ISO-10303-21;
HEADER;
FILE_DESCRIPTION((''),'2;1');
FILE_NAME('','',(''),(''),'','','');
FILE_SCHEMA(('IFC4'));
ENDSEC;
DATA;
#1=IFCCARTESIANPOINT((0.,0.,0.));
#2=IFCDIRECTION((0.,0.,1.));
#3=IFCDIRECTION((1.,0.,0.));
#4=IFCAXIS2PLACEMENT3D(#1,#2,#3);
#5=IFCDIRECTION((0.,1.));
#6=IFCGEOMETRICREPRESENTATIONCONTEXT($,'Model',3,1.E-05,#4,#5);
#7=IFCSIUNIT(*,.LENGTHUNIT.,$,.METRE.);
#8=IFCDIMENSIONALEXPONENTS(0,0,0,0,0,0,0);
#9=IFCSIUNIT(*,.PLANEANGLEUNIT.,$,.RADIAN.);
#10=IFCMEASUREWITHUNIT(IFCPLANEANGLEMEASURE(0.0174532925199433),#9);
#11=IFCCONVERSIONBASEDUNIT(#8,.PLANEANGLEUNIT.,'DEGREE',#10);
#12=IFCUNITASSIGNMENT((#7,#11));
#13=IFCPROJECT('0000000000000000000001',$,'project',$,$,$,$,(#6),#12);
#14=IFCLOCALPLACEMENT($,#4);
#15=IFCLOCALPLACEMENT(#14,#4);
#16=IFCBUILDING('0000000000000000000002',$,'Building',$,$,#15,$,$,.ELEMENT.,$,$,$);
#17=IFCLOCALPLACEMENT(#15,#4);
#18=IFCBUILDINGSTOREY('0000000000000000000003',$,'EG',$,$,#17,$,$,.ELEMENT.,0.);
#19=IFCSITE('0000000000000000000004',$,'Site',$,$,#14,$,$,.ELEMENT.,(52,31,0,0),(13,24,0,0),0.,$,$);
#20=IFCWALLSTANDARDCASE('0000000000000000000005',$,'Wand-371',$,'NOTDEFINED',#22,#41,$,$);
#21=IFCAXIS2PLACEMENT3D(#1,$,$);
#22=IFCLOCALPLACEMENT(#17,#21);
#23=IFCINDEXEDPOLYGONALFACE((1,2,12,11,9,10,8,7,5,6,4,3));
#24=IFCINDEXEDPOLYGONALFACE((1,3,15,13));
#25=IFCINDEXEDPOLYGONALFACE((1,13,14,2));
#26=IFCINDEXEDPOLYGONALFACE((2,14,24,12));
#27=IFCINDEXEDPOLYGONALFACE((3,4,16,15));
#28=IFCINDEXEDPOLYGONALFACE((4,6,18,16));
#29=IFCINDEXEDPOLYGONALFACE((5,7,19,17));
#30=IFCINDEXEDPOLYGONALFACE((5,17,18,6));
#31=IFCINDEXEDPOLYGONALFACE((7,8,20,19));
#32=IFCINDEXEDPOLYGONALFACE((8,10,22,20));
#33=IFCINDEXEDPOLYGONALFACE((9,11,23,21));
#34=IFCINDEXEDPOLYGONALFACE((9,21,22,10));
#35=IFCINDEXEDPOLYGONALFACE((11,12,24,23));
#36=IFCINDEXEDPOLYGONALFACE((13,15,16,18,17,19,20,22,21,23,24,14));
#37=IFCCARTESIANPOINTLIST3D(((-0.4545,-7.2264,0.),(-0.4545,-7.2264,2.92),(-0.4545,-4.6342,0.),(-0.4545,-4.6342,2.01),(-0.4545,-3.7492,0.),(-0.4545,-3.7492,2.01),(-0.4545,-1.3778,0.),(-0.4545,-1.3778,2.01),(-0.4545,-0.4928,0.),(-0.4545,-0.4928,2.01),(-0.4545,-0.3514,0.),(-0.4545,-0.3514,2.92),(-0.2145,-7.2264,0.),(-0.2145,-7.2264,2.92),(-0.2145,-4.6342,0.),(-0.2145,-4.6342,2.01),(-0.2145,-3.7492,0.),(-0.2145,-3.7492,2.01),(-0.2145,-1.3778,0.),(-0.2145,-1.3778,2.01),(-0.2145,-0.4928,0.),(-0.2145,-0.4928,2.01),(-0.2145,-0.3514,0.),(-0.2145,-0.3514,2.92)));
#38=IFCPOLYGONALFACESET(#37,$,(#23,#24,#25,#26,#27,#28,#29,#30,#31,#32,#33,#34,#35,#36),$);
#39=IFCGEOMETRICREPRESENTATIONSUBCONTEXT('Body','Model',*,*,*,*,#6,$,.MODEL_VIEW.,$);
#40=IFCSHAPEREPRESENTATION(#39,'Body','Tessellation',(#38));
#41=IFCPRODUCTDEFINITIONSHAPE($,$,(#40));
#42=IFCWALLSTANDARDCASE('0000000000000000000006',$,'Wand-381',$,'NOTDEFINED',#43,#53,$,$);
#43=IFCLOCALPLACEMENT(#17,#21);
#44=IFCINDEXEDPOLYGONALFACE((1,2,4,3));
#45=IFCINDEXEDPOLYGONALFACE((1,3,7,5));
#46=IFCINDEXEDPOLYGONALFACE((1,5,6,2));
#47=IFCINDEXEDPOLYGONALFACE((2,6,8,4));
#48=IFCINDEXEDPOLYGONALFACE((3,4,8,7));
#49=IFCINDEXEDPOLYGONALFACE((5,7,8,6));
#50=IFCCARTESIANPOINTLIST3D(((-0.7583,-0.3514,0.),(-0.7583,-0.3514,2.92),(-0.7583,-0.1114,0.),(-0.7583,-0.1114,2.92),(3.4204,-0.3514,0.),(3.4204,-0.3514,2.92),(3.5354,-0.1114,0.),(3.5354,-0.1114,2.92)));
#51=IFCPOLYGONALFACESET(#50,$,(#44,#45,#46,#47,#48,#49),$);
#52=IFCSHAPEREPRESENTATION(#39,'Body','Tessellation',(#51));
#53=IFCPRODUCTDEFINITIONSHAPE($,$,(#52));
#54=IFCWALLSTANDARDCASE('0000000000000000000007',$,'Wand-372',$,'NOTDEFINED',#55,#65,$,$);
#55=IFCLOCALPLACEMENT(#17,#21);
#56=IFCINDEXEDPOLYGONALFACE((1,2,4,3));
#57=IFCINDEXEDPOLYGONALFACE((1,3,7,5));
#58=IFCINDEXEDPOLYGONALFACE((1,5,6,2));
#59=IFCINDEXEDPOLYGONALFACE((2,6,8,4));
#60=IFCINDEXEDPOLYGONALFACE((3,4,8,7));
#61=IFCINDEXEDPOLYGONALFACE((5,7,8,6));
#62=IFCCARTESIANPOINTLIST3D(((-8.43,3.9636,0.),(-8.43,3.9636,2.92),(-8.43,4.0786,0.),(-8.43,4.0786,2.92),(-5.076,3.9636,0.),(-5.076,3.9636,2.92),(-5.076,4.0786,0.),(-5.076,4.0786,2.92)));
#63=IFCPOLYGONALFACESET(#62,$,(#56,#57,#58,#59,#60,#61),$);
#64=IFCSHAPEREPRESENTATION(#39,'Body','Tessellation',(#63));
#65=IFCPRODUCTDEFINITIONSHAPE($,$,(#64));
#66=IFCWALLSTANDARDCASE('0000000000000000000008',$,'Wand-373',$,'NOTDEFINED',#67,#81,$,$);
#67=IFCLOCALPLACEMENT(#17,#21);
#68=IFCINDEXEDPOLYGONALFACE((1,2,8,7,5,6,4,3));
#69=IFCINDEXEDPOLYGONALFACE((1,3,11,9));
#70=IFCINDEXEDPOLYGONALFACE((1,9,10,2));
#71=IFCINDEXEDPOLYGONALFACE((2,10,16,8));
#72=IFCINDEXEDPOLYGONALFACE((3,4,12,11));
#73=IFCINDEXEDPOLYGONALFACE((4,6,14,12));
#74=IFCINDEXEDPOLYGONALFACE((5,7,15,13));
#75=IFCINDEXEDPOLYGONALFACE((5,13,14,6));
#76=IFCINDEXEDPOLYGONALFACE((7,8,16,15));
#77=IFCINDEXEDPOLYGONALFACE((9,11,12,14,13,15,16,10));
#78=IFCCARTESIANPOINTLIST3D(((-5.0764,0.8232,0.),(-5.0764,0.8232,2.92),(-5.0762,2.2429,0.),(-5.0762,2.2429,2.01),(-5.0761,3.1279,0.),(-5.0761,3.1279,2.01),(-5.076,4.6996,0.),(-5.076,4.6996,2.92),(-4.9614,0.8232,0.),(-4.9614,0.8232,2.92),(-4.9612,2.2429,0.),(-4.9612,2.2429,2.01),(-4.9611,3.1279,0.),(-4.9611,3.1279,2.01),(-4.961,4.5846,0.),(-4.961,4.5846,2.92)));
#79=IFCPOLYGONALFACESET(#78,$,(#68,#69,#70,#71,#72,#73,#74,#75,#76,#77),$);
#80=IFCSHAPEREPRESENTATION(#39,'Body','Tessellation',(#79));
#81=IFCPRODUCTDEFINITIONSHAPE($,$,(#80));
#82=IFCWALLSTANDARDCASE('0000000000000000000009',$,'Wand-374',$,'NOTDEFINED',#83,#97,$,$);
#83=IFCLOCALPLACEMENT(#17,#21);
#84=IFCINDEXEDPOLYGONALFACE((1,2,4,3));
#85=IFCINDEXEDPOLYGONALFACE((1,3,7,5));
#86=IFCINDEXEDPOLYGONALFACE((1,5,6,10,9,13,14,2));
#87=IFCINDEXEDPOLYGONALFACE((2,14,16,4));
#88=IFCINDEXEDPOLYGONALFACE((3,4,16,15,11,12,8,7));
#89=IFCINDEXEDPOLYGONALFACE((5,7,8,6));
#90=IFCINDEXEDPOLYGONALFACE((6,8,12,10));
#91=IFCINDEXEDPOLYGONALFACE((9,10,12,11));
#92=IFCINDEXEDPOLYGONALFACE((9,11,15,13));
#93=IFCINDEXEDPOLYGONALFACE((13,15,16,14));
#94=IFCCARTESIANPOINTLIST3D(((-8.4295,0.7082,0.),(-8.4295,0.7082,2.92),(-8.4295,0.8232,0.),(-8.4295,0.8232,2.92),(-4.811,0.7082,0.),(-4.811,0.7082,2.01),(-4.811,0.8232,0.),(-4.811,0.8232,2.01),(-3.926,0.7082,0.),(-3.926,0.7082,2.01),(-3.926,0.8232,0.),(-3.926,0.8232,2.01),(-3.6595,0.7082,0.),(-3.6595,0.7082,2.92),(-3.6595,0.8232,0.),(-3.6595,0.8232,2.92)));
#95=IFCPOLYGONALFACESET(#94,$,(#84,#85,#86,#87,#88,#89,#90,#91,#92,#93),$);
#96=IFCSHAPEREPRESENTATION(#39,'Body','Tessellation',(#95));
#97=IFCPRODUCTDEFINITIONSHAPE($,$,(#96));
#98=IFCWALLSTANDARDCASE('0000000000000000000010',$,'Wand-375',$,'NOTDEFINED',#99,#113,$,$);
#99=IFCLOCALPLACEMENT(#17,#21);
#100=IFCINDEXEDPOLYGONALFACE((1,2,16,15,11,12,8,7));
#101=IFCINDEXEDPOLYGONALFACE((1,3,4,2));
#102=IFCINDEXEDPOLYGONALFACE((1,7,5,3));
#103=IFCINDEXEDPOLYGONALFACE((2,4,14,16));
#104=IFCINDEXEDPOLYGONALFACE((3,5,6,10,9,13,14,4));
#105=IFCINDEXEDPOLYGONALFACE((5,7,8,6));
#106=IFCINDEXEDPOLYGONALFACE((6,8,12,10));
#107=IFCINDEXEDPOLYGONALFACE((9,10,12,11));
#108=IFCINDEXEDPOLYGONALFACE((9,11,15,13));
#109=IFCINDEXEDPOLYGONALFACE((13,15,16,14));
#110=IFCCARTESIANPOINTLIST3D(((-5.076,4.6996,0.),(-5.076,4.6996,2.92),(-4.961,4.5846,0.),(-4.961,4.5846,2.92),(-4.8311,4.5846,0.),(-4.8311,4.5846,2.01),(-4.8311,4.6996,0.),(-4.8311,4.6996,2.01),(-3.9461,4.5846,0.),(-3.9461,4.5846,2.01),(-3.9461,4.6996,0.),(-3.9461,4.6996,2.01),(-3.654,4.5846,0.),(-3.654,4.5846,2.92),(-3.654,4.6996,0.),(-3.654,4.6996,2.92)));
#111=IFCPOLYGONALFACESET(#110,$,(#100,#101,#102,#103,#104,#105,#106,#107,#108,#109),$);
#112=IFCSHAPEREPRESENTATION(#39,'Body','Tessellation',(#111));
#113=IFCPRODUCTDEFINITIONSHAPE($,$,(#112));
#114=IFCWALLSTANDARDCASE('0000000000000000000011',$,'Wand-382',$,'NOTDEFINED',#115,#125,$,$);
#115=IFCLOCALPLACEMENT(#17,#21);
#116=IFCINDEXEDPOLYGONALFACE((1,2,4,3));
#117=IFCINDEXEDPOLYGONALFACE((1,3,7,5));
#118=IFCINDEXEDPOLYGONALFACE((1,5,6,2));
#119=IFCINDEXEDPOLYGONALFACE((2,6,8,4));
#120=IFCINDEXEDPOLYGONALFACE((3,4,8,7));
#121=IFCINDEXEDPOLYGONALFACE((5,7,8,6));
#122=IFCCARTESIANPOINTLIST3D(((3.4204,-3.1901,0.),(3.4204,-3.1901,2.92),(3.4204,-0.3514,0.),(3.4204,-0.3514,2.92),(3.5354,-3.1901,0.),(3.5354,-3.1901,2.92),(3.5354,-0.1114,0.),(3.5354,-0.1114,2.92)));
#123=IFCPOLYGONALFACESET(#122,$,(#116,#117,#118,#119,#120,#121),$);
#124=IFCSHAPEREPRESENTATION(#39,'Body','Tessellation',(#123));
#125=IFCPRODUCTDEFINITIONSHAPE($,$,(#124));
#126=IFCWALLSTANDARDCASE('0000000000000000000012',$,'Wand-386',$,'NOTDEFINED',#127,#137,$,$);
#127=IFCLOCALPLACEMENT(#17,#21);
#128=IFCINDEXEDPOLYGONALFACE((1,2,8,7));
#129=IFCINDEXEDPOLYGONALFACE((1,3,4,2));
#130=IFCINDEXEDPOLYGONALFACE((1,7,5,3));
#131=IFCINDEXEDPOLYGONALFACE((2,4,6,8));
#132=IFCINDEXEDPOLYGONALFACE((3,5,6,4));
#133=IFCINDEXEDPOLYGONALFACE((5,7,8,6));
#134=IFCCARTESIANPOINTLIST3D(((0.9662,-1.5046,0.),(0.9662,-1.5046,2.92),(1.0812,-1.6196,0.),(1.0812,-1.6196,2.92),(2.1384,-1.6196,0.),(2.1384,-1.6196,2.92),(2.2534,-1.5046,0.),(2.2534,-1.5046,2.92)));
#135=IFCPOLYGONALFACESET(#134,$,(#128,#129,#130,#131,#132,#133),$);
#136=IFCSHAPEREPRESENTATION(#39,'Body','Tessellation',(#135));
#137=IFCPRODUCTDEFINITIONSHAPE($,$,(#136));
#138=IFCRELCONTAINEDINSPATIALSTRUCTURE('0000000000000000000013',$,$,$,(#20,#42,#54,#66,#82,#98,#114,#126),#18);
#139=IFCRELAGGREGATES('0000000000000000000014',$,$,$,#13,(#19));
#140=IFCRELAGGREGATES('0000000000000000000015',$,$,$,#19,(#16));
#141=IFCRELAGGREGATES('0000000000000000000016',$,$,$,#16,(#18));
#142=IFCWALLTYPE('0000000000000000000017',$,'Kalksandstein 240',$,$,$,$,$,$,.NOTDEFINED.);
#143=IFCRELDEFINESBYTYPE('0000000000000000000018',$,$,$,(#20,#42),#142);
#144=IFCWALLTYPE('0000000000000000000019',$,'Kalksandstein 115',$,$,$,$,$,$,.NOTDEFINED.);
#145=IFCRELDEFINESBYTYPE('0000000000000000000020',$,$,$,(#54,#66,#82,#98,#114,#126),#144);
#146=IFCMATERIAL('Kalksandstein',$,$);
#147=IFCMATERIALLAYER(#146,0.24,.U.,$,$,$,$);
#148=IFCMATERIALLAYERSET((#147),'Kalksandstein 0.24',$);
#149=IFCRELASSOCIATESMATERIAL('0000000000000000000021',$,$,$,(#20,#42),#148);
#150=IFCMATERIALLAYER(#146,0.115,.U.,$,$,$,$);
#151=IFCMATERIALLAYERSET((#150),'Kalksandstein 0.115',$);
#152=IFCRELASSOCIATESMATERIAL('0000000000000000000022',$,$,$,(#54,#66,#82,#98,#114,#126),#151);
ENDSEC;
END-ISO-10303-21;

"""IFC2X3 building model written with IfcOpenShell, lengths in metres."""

from ifc_helpers import new_model, entity, si_unit, converted_unit, direction, frame, origin_with_axes, origin_2d_with_axis, place, context, subcontext, project, spatial, polyline, rectangle, outline, extrude, material, layer, layer_set, layer_usage, type_object, element, save


model = new_model("IFC2X3")

# Units and contexts
model_context = context("Model", 3, precision=1e-05, world=origin_with_axes(), true_north=direction((0.0, 1.0)))
body_context = subcontext(model_context, "Body", "Model", "MODEL_VIEW")
ifc_project = project(units=[si_unit("LENGTHUNIT", "METRE"), converted_unit("PLANEANGLEUNIT", "DEGREE", entity("IfcPlaneAngleMeasure", 0.0174532925199433), si_unit("PLANEANGLEUNIT", "RADIAN"), dimensions=[0, 0, 0, 0, 0, 0, 0])], contexts=[model_context])

# Site, building, storey
site_placement = place(None, origin_with_axes())
site = spatial("IfcSite", under=ifc_project, at=site_placement, Name="Site", CompositionType="ELEMENT", RefLatitude=(52, 31, 0, 0), RefLongitude=(13, 24, 0, 0), RefElevation=0.0)
building_placement = place(site_placement, origin_with_axes())
building = spatial("IfcBuilding", under=site, at=building_placement, Name="Building", CompositionType="ELEMENT")
storey_placement = place(building_placement, origin_with_axes())
storey = spatial("IfcBuildingStorey", under=building, at=storey_placement, Name="EG", CompositionType="ELEMENT", Elevation=0.0)

# Shared definitions
ifc_material_1 = material(Name="Kalksandstein")

# Wall, openings
ifc_layer_1 = layer(ifc_material_1, 0.24, ventilated="UNKNOWN")
ifc_layer_set_1 = layer_set([ifc_layer_1], Name="Kalksandstein 0.24")
wall_type_1 = type_object("IfcWallType", Name="Kalksandstein 240", PredefinedType="NOTDEFINED")
ifc_layer_usage_1 = layer_usage(ifc_layer_set_1, "AXIS2", "NEGATIVE", 0.0)
wall_1_placement = place(storey_placement, frame((-0.2145, -0.3514, 0.0), z_axis=(0.0, 0.0, 1.0), x_axis=(0.0, -1.0, 0.0)))
wall_1 = element("IfcWallStandardCase", 1, at=wall_1_placement, inside=storey, type_object=wall_type_1, material=ifc_layer_usage_1, Name="Wand-371", ObjectType="NOTDEFINED", context=body_context, shape_type="SweptSolid", body=[
    extrude(outline(polyline([(0.0, -0.24), (6.875, -0.24), (6.875, 0.0), (0.0, 0.0), (0.0, -0.24)])), origin_with_axes(), (0.0, 0.0, 1.0), 2.92),
])
opening_1_placement = place(wall_1_placement, frame((3.8404, 0.0, 0.0), z_axis=(0.0, 0.0, 1.0), x_axis=(1.0, 0.0, 0.0)))
element("IfcOpeningElement", 2, at=opening_1_placement, cuts=wall_1, context=body_context, shape_type="SweptSolid", body=[
    extrude(rectangle(XDim=0.885, YDim=2.01, at=origin_2d_with_axis()), frame((0.0, -0.24, 1.005), z_axis=(0.0, -1.0, 0.0), x_axis=(-1.0, 0.0, 0.0)), (0.0, 0.0, -1.0), 0.72),
])
opening_2_placement = place(wall_1_placement, frame((0.584, 0.0, 0.0), z_axis=(0.0, 0.0, 1.0), x_axis=(1.0, 0.0, 0.0)))
element("IfcOpeningElement", 3, at=opening_2_placement, cuts=wall_1, context=body_context, shape_type="SweptSolid", body=[
    extrude(rectangle(XDim=0.885, YDim=2.01, at=origin_2d_with_axis()), frame((0.0, -0.24, 1.005), z_axis=(0.0, -1.0, 0.0), x_axis=(-1.0, 0.0, 0.0)), (0.0, 0.0, -1.0), 0.72),
])

# Walls
ifc_layer_usage_2 = layer_usage(ifc_layer_set_1, "AXIS2", "POSITIVE", 0.0)
wall_2_placement = place(storey_placement, frame((-0.7583, -0.3514, 0.0), z_axis=(0.0, 0.0, 1.0), x_axis=(1.0, 0.0, 0.0)))
element("IfcWallStandardCase", 4, at=wall_2_placement, inside=storey, type_object=wall_type_1, material=ifc_layer_usage_2, Name="Wand-381", ObjectType="NOTDEFINED", context=body_context, shape_type="SweptSolid", body=[
    extrude(outline(polyline([(0.0, 0.0), (4.1787, 0.0), (4.2937, 0.24), (0.0, 0.24), (0.0, 0.0)])), origin_with_axes(), (0.0, 0.0, 1.0), 2.92),
])
ifc_layer_2 = layer(ifc_material_1, 0.115, ventilated="UNKNOWN")
ifc_layer_set_2 = layer_set([ifc_layer_2], Name="Kalksandstein 0.115")
ifc_layer_usage_3 = layer_usage(ifc_layer_set_2, "AXIS2", "NEGATIVE", 0.0)
wall_type_2 = type_object("IfcWallType", Name="Kalksandstein 115", PredefinedType="NOTDEFINED")
wall_3_placement = place(storey_placement, frame((-8.43, 4.0786, 0.0), z_axis=(0.0, 0.0, 1.0), x_axis=(1.0, 0.0, 0.0)))
element("IfcWallStandardCase", 5, at=wall_3_placement, inside=storey, type_object=wall_type_2, material=ifc_layer_usage_3, Name="Wand-372", ObjectType="NOTDEFINED", context=body_context, shape_type="SweptSolid", body=[
    extrude(outline(polyline([(0.0, -0.115), (3.3539, -0.115), (3.3539, 0.0), (0.0, 0.0), (0.0, -0.115)])), origin_with_axes(), (0.0, 0.0, 1.0), 2.92),
])

# Walls, openings
ifc_layer_usage_4 = layer_usage(ifc_layer_set_2, "AXIS2", "NEGATIVE", 0.0)
wall_4_placement = place(storey_placement, frame((-4.961, 4.5846, 0.0), z_axis=(0.0, 0.0, 1.0), x_axis=(-0.000102, -1.0, 0.0)))
wall_4 = element("IfcWallStandardCase", 6, at=wall_4_placement, inside=storey, type_object=wall_type_2, material=ifc_layer_usage_4, Name="Wand-373", ObjectType="NOTDEFINED", context=body_context, shape_type="SweptSolid", body=[
    extrude(outline(polyline([(-0.115, -0.115), (3.7614, -0.115), (3.7614, 0.0), (0.0, 0.0), (-0.115, -0.115)])), origin_with_axes(), (0.0, 0.0, 1.0), 2.92),
])
opening_3_placement = place(wall_4_placement, frame((1.8992, 0.0, 0.0), z_axis=(0.0, 0.0, 1.0), x_axis=(1.0, 0.0, 0.0)))
element("IfcOpeningElement", 7, at=opening_3_placement, cuts=wall_4, context=body_context, shape_type="SweptSolid", body=[
    extrude(rectangle(XDim=0.885, YDim=2.01, at=origin_2d_with_axis()), frame((0.0, 0.115, 1.005), z_axis=(0.0, 1.0, 0.0), x_axis=(1.0, 0.0, 0.0)), (0.0, 0.0, -1.0), 0.345),
])
ifc_layer_usage_5 = layer_usage(ifc_layer_set_2, "AXIS2", "NEGATIVE", 0.0)
wall_5_placement = place(storey_placement, frame((-3.6595, 0.7082, 0.0), z_axis=(0.0, 0.0, 1.0), x_axis=(-1.0, 0.0, 0.0)))
wall_5 = element("IfcWallStandardCase", 8, at=wall_5_placement, inside=storey, type_object=wall_type_2, material=ifc_layer_usage_5, Name="Wand-374", ObjectType="NOTDEFINED", context=body_context, shape_type="SweptSolid", body=[
    extrude(outline(polyline([(0.0, -0.115), (4.77, -0.115), (4.77, 0.0), (0.0, 0.0), (0.0, -0.115)])), origin_with_axes(), (0.0, 0.0, 1.0), 2.92),
])
opening_4_placement = place(wall_5_placement, frame((0.709, 0.0, 0.0), z_axis=(0.0, 0.0, 1.0), x_axis=(1.0, 0.0, 0.0)))
element("IfcOpeningElement", 9, at=opening_4_placement, cuts=wall_5, context=body_context, shape_type="SweptSolid", body=[
    extrude(rectangle(XDim=0.885, YDim=2.01, at=origin_2d_with_axis()), frame((0.0, -0.115, 1.005), z_axis=(0.0, -1.0, 0.0), x_axis=(-1.0, 0.0, 0.0)), (0.0, 0.0, -1.0), 0.345),
])
ifc_layer_usage_6 = layer_usage(ifc_layer_set_2, "AXIS2", "POSITIVE", 0.0)
wall_6_placement = place(storey_placement, frame((-4.961, 4.5846, 0.0), z_axis=(0.0, 0.0, 1.0), x_axis=(1.0, 0.0, 0.0)))
wall_6 = element("IfcWallStandardCase", 10, at=wall_6_placement, inside=storey, type_object=wall_type_2, material=ifc_layer_usage_6, Name="Wand-375", ObjectType="NOTDEFINED", context=body_context, shape_type="SweptSolid", body=[
    extrude(outline(polyline([(0.0, 0.0), (1.307, 0.0), (1.307, 0.115), (-0.115, 0.115), (0.0, 0.0)])), origin_with_axes(), (0.0, 0.0, 1.0), 2.92),
])
opening_5_placement = place(wall_6_placement, frame((0.5723, 0.0, 0.0), z_axis=(0.0, 0.0, 1.0), x_axis=(1.0, 0.0, 0.0)))
element("IfcOpeningElement", 11, at=opening_5_placement, cuts=wall_6, context=body_context, shape_type="SweptSolid", body=[
    extrude(rectangle(XDim=0.885, YDim=2.01, at=origin_2d_with_axis()), frame((0.0, -0.115, 1.005), z_axis=(0.0, 1.0, 0.0), x_axis=(1.0, 0.0, 0.0)), (0.0, 0.0, 1.0), 0.345),
])

# Walls
ifc_layer_usage_7 = layer_usage(ifc_layer_set_2, "AXIS2", "POSITIVE", 0.0)
wall_7_placement = place(storey_placement, frame((3.4204, -0.3514, 0.0), z_axis=(0.0, 0.0, 1.0), x_axis=(0.0, -1.0, 0.0)))
element("IfcWallStandardCase", 12, at=wall_7_placement, inside=storey, type_object=wall_type_2, material=ifc_layer_usage_7, Name="Wand-382", ObjectType="NOTDEFINED", context=body_context, shape_type="SweptSolid", body=[
    extrude(outline(polyline([(0.0, 0.0), (2.8388, 0.0), (2.8388, 0.115), (-0.24, 0.115), (0.0, 0.0)])), origin_with_axes(), (0.0, 0.0, 1.0), 2.92),
])
ifc_layer_usage_8 = layer_usage(ifc_layer_set_2, "AXIS2", "NEGATIVE", 0.0)
wall_8_placement = place(storey_placement, frame((0.9662, -1.5046, 0.0), z_axis=(0.0, 0.0, 1.0), x_axis=(1.0, 0.0, 0.0)))
element("IfcWallStandardCase", 13, at=wall_8_placement, inside=storey, type_object=wall_type_2, material=ifc_layer_usage_8, Name="Wand-386", ObjectType="NOTDEFINED", context=body_context, shape_type="SweptSolid", body=[
    extrude(outline(polyline([(0.115, -0.115), (1.1721, -0.115), (1.2871, 0.0), (0.0, 0.0), (0.115, -0.115)])), origin_with_axes(), (0.0, 0.0, 1.0), 2.92),
])

save(model, "model.ifc")
